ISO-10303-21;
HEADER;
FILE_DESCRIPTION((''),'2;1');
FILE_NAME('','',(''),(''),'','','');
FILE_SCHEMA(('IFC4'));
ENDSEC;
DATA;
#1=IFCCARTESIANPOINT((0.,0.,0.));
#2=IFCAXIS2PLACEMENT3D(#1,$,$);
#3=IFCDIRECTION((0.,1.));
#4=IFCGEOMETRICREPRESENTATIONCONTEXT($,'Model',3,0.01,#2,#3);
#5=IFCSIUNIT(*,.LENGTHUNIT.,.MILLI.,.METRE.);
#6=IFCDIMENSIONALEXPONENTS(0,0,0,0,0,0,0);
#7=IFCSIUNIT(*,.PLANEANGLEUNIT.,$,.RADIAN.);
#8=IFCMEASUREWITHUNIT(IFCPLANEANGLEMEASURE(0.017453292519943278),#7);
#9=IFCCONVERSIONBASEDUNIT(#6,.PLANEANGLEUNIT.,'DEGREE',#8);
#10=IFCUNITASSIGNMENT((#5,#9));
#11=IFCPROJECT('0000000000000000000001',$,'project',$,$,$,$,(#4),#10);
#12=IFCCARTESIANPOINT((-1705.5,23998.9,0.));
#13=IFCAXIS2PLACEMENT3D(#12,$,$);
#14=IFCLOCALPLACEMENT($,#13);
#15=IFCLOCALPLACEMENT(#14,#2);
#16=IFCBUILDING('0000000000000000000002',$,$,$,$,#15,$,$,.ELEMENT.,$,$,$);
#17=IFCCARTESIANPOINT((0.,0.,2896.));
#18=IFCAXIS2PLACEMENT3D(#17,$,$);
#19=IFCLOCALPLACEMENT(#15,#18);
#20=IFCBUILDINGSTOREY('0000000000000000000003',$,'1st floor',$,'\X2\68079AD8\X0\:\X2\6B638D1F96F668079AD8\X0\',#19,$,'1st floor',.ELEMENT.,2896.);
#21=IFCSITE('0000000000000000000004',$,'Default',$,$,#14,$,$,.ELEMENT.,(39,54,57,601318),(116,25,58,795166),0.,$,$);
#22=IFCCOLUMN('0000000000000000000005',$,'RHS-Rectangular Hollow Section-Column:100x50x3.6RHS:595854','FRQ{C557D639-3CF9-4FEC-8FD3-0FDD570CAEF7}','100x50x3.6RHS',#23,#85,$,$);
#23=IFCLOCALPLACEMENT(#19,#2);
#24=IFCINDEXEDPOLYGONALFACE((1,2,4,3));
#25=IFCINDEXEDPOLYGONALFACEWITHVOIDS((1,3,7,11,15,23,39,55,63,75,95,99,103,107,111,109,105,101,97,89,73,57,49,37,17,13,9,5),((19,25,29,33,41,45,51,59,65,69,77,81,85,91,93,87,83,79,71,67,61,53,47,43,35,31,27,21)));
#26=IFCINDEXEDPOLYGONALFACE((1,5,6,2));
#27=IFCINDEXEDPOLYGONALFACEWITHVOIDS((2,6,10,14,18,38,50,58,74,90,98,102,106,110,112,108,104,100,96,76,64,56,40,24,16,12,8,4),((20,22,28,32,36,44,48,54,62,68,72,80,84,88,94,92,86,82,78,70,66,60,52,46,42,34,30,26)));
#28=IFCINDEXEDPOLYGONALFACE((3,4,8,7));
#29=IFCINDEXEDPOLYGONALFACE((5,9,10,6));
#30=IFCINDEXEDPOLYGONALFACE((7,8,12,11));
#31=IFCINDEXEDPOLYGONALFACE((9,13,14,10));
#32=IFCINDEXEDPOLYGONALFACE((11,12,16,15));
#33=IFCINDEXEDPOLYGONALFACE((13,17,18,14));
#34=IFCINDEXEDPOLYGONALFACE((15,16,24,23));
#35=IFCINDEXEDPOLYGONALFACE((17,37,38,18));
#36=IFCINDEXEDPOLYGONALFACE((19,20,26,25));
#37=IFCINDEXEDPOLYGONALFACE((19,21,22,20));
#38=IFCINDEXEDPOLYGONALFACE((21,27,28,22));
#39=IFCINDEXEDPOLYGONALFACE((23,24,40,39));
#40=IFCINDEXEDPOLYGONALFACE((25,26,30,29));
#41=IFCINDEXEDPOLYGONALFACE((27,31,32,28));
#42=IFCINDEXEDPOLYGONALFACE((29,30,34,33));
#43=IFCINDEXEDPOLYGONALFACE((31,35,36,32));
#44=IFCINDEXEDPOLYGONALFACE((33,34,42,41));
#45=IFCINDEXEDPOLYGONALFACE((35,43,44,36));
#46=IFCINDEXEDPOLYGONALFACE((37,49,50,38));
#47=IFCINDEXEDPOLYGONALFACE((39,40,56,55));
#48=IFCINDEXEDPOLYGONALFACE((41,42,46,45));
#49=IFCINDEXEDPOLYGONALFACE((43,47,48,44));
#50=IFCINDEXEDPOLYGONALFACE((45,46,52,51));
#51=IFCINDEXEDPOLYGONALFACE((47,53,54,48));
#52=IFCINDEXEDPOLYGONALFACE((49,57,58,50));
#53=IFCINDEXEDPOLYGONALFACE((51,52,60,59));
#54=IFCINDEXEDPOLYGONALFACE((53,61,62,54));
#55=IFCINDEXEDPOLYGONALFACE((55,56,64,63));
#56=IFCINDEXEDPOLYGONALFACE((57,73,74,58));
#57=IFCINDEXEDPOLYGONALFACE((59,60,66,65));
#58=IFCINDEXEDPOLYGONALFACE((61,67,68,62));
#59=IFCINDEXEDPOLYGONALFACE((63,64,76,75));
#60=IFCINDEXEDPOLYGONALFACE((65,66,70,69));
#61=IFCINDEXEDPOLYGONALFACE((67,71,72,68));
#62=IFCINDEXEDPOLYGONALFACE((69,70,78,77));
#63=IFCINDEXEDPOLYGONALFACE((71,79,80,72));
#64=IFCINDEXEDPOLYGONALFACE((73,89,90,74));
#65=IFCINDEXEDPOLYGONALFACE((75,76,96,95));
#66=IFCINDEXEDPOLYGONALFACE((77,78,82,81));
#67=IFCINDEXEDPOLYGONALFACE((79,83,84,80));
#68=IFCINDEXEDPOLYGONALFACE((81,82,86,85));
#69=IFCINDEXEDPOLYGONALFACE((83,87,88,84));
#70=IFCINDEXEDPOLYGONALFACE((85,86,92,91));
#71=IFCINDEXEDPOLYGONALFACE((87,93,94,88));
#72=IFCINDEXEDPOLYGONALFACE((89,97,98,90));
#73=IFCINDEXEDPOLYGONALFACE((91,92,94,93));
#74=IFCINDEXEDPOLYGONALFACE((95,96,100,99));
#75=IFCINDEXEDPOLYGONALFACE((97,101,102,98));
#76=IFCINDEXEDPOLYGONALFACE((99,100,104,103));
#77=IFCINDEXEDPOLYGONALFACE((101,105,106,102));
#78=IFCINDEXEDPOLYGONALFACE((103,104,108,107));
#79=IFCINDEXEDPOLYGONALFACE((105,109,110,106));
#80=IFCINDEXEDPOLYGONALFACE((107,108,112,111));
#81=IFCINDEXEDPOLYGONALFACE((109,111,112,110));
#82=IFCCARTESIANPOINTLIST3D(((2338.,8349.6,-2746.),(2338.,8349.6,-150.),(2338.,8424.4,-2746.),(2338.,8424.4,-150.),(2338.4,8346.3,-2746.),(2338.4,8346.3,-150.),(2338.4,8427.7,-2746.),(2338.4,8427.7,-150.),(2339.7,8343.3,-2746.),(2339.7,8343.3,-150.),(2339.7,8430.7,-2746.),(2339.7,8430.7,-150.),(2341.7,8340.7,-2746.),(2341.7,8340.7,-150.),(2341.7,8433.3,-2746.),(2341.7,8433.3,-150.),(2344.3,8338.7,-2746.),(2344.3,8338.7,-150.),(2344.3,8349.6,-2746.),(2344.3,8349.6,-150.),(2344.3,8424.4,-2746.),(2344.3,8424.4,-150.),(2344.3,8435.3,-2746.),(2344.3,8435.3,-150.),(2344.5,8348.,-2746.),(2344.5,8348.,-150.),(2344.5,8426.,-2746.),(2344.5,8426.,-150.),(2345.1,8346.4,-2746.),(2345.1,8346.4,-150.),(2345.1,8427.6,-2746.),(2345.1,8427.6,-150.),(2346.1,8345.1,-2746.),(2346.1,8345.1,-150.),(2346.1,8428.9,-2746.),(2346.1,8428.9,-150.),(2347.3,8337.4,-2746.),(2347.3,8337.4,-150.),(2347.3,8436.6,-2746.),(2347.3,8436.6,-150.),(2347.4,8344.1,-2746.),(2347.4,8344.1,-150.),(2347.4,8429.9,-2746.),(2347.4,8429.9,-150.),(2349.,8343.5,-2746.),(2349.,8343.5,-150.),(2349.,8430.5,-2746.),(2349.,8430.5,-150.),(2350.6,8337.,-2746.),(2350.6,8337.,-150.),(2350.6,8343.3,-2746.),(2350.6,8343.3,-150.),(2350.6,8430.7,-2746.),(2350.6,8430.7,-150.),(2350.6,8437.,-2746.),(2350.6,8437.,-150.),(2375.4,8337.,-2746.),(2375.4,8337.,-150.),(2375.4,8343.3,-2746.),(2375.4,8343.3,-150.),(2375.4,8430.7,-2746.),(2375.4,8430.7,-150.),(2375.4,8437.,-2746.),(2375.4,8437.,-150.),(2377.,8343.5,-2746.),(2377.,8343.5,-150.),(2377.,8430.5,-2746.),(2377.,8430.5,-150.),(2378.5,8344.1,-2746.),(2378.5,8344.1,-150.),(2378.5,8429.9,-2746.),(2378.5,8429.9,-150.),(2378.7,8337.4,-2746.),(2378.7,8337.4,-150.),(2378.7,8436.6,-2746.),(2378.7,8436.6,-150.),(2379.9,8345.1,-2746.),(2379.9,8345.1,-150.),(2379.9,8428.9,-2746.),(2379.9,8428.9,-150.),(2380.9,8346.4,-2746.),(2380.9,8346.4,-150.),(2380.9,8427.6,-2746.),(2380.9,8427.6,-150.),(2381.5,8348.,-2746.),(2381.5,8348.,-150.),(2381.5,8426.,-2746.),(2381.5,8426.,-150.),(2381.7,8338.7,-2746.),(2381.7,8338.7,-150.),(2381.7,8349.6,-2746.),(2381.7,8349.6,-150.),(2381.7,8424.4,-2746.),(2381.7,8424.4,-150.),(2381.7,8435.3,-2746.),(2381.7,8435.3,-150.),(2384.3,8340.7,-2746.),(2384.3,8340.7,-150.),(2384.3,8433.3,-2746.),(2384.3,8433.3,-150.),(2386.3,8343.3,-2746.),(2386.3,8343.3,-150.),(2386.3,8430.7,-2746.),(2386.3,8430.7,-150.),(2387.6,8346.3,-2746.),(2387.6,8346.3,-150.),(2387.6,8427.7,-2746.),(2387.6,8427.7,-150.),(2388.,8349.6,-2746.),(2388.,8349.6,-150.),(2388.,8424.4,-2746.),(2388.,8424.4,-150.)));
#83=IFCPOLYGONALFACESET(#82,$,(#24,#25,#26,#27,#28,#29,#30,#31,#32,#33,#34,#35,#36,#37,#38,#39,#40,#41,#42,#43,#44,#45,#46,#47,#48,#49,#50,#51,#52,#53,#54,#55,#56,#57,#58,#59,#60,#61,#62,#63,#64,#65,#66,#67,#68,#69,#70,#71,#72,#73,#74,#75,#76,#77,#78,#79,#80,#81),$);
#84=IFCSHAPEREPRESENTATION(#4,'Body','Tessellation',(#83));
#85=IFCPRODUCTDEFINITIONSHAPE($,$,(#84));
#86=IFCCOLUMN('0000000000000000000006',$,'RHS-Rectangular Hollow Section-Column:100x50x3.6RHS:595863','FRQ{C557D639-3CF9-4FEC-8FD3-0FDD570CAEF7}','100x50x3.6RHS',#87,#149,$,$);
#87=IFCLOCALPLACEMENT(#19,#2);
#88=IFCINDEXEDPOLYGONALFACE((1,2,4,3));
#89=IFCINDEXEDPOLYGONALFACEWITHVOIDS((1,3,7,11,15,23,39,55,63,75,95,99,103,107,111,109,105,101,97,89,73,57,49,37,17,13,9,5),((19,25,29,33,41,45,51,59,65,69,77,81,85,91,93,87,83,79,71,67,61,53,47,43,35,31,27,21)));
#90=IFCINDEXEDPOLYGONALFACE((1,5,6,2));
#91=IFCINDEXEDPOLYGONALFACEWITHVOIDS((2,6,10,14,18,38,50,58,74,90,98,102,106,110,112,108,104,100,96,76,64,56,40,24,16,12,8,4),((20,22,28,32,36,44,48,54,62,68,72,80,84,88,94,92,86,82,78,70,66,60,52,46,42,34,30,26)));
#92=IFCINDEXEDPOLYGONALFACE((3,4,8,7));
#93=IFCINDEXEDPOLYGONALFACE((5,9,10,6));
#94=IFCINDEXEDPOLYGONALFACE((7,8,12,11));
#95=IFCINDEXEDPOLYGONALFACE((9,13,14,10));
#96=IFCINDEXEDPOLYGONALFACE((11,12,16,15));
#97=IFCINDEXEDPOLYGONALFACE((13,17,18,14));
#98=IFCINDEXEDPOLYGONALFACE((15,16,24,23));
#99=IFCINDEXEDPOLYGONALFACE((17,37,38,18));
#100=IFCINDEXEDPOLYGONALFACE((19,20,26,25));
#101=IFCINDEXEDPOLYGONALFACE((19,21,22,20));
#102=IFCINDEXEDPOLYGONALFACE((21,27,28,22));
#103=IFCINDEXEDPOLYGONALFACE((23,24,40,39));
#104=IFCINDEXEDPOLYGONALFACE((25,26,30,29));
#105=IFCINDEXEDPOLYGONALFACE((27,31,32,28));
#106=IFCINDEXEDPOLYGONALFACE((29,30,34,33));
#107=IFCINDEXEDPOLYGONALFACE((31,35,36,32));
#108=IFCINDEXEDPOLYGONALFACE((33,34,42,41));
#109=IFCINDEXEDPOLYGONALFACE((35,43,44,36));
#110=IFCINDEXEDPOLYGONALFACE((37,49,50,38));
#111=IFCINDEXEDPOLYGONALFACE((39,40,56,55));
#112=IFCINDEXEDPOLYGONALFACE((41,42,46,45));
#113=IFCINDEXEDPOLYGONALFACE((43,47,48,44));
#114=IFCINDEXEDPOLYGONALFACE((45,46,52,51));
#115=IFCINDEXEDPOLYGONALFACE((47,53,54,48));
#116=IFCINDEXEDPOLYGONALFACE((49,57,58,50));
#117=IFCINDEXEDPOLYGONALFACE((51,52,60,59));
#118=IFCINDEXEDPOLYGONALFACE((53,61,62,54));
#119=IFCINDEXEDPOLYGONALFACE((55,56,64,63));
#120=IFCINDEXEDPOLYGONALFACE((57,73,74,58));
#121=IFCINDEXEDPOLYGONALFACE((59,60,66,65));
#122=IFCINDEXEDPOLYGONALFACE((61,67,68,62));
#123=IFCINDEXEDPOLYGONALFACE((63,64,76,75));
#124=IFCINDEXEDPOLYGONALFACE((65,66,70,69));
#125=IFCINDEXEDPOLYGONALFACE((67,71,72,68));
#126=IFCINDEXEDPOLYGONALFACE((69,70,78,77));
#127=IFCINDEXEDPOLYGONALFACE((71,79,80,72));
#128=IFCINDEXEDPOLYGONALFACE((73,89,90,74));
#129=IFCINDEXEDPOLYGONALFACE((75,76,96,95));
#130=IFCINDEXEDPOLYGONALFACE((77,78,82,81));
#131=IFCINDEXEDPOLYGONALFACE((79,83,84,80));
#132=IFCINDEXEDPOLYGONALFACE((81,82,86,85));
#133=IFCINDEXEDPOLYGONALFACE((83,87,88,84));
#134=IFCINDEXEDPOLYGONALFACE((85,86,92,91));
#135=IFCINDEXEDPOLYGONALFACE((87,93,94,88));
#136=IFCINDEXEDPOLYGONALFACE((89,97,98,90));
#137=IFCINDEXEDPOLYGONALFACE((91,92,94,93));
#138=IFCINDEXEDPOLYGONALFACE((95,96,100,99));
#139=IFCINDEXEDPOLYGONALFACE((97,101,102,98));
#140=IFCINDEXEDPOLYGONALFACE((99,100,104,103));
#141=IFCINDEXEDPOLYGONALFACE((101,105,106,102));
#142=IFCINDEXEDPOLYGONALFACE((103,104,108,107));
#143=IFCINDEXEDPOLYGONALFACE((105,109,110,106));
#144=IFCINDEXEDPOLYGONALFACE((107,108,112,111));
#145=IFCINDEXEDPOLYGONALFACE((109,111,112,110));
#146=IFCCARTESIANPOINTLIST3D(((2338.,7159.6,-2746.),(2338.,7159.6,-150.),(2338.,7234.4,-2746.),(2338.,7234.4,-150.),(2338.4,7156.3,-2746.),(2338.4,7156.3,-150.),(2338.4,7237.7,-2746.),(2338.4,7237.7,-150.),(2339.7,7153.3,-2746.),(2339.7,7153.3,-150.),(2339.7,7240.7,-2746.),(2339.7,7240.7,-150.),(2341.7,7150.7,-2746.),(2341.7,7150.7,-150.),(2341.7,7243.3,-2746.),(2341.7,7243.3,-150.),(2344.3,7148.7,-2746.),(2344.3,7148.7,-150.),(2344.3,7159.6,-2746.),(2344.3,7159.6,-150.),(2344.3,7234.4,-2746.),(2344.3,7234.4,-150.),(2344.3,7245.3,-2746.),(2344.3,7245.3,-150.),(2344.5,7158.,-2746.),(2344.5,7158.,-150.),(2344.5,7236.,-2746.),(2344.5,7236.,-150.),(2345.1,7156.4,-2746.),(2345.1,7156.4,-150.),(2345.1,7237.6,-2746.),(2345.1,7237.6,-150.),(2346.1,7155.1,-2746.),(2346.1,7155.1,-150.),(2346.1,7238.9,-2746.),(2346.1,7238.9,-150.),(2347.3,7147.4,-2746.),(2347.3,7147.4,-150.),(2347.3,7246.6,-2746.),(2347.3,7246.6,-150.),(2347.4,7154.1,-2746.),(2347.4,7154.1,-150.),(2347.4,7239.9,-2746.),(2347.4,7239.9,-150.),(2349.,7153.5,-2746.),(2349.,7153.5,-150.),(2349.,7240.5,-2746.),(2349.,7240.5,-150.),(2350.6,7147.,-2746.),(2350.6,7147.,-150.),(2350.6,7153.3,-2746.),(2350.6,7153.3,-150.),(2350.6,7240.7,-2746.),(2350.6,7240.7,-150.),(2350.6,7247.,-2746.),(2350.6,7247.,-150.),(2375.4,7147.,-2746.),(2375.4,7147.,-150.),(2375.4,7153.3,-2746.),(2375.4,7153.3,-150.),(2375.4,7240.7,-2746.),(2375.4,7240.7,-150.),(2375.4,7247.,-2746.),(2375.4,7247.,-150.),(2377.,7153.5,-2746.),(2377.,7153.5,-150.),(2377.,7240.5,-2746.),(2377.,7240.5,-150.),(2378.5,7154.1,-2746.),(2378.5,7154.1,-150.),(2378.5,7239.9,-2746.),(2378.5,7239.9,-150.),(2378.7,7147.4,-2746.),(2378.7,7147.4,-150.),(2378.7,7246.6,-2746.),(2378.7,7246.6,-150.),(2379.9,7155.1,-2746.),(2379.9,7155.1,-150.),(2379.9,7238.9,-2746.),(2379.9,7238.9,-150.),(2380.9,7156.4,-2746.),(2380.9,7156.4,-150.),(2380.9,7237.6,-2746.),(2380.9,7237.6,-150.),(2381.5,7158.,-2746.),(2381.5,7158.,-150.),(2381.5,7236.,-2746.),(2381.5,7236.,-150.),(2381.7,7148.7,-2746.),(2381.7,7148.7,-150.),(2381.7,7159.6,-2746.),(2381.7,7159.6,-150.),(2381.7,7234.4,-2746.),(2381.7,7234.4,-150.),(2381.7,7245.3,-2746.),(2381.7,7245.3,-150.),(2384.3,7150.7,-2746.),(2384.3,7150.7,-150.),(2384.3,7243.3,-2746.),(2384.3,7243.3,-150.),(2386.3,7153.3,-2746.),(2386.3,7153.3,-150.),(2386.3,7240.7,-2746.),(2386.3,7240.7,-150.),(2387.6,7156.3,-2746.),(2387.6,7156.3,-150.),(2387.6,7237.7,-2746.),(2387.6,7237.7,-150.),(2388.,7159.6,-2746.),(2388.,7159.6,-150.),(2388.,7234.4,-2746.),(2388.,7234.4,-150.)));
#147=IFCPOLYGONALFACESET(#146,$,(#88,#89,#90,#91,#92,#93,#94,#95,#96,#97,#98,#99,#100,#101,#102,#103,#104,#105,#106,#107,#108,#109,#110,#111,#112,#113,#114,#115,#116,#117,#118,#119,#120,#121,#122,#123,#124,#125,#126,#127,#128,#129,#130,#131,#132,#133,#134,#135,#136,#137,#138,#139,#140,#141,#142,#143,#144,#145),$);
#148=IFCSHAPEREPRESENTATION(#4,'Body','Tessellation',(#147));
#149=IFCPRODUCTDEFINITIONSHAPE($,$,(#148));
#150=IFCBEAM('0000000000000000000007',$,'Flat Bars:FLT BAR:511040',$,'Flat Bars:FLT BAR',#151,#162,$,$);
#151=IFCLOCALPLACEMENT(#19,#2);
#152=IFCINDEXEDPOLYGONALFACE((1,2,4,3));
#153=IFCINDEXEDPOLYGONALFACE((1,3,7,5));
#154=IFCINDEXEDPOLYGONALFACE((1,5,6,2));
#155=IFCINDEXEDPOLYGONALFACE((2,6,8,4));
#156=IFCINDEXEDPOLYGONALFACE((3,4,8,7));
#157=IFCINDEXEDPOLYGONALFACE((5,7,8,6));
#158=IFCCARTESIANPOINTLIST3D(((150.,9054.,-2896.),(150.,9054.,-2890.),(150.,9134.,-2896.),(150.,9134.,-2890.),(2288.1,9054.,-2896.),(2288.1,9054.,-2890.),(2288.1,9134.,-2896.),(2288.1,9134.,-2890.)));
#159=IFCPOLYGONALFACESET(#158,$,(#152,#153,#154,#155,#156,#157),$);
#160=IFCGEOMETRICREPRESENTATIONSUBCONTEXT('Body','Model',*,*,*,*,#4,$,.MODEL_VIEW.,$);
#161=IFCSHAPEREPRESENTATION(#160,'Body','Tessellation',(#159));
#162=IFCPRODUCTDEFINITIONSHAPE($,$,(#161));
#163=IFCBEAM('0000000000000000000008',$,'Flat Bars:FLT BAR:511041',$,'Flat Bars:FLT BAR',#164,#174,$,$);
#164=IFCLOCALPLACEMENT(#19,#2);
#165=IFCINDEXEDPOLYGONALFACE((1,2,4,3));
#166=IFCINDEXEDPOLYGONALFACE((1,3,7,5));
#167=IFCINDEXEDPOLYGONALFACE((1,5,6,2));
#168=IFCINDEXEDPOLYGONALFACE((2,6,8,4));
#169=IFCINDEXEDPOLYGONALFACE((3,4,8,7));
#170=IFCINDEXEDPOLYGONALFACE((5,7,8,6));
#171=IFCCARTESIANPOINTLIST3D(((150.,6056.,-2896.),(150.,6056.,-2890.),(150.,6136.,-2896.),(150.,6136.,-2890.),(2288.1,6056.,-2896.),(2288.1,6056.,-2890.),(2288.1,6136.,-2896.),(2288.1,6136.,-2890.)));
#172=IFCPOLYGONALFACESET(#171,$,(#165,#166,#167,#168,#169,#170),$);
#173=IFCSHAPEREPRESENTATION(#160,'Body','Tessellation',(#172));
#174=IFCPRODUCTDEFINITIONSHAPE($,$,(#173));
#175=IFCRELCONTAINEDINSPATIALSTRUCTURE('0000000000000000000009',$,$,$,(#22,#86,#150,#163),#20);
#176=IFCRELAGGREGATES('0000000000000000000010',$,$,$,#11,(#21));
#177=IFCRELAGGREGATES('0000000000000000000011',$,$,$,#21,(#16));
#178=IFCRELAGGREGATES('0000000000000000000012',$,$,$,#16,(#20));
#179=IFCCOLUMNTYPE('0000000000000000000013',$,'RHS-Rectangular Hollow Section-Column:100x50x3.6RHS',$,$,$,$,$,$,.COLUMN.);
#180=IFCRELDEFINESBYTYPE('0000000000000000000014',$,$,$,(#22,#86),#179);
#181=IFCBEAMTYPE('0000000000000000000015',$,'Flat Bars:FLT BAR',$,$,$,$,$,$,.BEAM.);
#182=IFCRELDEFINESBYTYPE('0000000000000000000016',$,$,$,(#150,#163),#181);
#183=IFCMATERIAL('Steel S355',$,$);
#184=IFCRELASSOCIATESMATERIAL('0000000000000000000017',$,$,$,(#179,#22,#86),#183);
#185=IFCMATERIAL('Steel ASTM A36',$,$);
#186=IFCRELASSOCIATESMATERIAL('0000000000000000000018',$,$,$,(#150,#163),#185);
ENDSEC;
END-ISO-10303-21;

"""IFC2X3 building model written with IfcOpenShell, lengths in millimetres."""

from ifc_helpers import new_model, entity, si_unit, converted_unit, direction, frame, origin, origin_2d, origin_2d_with_axis, place, context, subcontext, project, spatial, rectangle, hollow_rectangle, extrude, clip, halfspace, material, type_object, element, save


model = new_model("IFC2X3")

# Units and contexts
model_context = context("Model", 3, precision=0.01, world=origin(), true_north=direction((0.0, 1.0)))
body_context = subcontext(model_context, "Body", "Model", "MODEL_VIEW")
ifc_project = project(units=[si_unit("LENGTHUNIT", "METRE", prefix="MILLI"), converted_unit("PLANEANGLEUNIT", "DEGREE", entity("IfcPlaneAngleMeasure", 0.017453292519943278), si_unit("PLANEANGLEUNIT", "RADIAN"), dimensions=[0, 0, 0, 0, 0, 0, 0])], contexts=[model_context])

# Site, building, storey
site_placement = place(None, frame((-1705.5, 23998.9, 0.0)))
site = spatial("IfcSite", under=ifc_project, at=site_placement, Name="Default", CompositionType="ELEMENT", RefLatitude=(39, 54, 57, 601318), RefLongitude=(116, 25, 58, 795166), RefElevation=0.0)
building_placement = place(site_placement, origin())
building = spatial("IfcBuilding", under=site, at=building_placement, CompositionType="ELEMENT")
storey_placement = place(building_placement, frame((0.0, 0.0, 2896.0)))
storey = spatial("IfcBuildingStorey", under=building, at=storey_placement, Name="1st floor", ObjectType="标高:正负零标高", LongName="1st floor", CompositionType="ELEMENT", Elevation=2896.0)

# Columns
ifc_material_1 = material(Name="Steel S355")
column_type = type_object("IfcColumnType", Name="RHS-Rectangular Hollow Section-Column:100x50x3.6RHS", PredefinedType="COLUMN", material=ifc_material_1)
column_1_placement = place(storey_placement, frame((2363.0, 8387.0, -150.0), z_axis=(0.0, 0.0, 1.0), x_axis=(-1.0, 0.0, 0.0)))
element("IfcColumn", 1, at=column_1_placement, inside=storey, type_object=column_type, material=ifc_material_1, Name="RHS-Rectangular Hollow Section-Column:100x50x3.6RHS:595854", Description="FRQ{C557D639-3CF9-4FEC-8FD3-0FDD570CAEF7}", ObjectType="100x50x3.6RHS", context=model_context, shape_type="Clipping", body=[
    clip(extrude(hollow_rectangle(XDim=50.0, YDim=100.0, WallThickness=6.3, InnerFilletRadius=6.3, OuterFilletRadius=12.6, at=origin_2d()), origin(), (0.0, 0.0, -1.0), 2651.9), halfspace(frame((2363.0, 8387.0, -2596.0), z_axis=(0.0, 0.0, 1.0), x_axis=(-1.0, 0.0, 0.0)), True)),
])
column_2_placement = place(storey_placement, frame((2363.0, 7197.0, -150.0), z_axis=(0.0, 0.0, 1.0), x_axis=(-1.0, 0.0, 0.0)))
element("IfcColumn", 2, at=column_2_placement, inside=storey, type_object=column_type, material=ifc_material_1, Name="RHS-Rectangular Hollow Section-Column:100x50x3.6RHS:595863", Description="FRQ{C557D639-3CF9-4FEC-8FD3-0FDD570CAEF7}", ObjectType="100x50x3.6RHS", context=model_context, shape_type="Clipping", body=[
    clip(extrude(hollow_rectangle(XDim=50.0, YDim=100.0, WallThickness=6.3, InnerFilletRadius=6.3, OuterFilletRadius=12.6, at=origin_2d()), origin(), (0.0, 0.0, -1.0), 2651.9), halfspace(frame((2363.0, 7197.0, -2596.0), z_axis=(0.0, 0.0, 1.0), x_axis=(-1.0, 0.0, 0.0)), True)),
])

# Beams
ifc_material_2 = material(Name="Steel ASTM A36")
beam_type_1 = type_object("IfcBeamType", Name="Flat Bars:FLT BAR", PredefinedType="BEAM")
for number, where, name in (
    (3, (150.0, 9094.0, -2890.0), "Flat Bars:FLT BAR:511040"),
    (4, (150.0, 6096.0, -2890.0), "Flat Bars:FLT BAR:511041"),
):
    element("IfcBeam", number, at=place(storey_placement, frame(where)), inside=storey, type_object=beam_type_1, material=ifc_material_2, Name=name, ObjectType="Flat Bars:FLT BAR", context=body_context, shape_type="SweptSolid", body=[
        extrude(rectangle(XDim=6.0, YDim=80.0, at=origin_2d_with_axis()), frame((0.0, 0.0, -3.0), z_axis=(1.0, 0.0, 0.0), x_axis=(0.0, 0.0, -1.0)), (0.0, 0.0, 1.0), 2138.1),
    ])

save(model, "model.ifc")
